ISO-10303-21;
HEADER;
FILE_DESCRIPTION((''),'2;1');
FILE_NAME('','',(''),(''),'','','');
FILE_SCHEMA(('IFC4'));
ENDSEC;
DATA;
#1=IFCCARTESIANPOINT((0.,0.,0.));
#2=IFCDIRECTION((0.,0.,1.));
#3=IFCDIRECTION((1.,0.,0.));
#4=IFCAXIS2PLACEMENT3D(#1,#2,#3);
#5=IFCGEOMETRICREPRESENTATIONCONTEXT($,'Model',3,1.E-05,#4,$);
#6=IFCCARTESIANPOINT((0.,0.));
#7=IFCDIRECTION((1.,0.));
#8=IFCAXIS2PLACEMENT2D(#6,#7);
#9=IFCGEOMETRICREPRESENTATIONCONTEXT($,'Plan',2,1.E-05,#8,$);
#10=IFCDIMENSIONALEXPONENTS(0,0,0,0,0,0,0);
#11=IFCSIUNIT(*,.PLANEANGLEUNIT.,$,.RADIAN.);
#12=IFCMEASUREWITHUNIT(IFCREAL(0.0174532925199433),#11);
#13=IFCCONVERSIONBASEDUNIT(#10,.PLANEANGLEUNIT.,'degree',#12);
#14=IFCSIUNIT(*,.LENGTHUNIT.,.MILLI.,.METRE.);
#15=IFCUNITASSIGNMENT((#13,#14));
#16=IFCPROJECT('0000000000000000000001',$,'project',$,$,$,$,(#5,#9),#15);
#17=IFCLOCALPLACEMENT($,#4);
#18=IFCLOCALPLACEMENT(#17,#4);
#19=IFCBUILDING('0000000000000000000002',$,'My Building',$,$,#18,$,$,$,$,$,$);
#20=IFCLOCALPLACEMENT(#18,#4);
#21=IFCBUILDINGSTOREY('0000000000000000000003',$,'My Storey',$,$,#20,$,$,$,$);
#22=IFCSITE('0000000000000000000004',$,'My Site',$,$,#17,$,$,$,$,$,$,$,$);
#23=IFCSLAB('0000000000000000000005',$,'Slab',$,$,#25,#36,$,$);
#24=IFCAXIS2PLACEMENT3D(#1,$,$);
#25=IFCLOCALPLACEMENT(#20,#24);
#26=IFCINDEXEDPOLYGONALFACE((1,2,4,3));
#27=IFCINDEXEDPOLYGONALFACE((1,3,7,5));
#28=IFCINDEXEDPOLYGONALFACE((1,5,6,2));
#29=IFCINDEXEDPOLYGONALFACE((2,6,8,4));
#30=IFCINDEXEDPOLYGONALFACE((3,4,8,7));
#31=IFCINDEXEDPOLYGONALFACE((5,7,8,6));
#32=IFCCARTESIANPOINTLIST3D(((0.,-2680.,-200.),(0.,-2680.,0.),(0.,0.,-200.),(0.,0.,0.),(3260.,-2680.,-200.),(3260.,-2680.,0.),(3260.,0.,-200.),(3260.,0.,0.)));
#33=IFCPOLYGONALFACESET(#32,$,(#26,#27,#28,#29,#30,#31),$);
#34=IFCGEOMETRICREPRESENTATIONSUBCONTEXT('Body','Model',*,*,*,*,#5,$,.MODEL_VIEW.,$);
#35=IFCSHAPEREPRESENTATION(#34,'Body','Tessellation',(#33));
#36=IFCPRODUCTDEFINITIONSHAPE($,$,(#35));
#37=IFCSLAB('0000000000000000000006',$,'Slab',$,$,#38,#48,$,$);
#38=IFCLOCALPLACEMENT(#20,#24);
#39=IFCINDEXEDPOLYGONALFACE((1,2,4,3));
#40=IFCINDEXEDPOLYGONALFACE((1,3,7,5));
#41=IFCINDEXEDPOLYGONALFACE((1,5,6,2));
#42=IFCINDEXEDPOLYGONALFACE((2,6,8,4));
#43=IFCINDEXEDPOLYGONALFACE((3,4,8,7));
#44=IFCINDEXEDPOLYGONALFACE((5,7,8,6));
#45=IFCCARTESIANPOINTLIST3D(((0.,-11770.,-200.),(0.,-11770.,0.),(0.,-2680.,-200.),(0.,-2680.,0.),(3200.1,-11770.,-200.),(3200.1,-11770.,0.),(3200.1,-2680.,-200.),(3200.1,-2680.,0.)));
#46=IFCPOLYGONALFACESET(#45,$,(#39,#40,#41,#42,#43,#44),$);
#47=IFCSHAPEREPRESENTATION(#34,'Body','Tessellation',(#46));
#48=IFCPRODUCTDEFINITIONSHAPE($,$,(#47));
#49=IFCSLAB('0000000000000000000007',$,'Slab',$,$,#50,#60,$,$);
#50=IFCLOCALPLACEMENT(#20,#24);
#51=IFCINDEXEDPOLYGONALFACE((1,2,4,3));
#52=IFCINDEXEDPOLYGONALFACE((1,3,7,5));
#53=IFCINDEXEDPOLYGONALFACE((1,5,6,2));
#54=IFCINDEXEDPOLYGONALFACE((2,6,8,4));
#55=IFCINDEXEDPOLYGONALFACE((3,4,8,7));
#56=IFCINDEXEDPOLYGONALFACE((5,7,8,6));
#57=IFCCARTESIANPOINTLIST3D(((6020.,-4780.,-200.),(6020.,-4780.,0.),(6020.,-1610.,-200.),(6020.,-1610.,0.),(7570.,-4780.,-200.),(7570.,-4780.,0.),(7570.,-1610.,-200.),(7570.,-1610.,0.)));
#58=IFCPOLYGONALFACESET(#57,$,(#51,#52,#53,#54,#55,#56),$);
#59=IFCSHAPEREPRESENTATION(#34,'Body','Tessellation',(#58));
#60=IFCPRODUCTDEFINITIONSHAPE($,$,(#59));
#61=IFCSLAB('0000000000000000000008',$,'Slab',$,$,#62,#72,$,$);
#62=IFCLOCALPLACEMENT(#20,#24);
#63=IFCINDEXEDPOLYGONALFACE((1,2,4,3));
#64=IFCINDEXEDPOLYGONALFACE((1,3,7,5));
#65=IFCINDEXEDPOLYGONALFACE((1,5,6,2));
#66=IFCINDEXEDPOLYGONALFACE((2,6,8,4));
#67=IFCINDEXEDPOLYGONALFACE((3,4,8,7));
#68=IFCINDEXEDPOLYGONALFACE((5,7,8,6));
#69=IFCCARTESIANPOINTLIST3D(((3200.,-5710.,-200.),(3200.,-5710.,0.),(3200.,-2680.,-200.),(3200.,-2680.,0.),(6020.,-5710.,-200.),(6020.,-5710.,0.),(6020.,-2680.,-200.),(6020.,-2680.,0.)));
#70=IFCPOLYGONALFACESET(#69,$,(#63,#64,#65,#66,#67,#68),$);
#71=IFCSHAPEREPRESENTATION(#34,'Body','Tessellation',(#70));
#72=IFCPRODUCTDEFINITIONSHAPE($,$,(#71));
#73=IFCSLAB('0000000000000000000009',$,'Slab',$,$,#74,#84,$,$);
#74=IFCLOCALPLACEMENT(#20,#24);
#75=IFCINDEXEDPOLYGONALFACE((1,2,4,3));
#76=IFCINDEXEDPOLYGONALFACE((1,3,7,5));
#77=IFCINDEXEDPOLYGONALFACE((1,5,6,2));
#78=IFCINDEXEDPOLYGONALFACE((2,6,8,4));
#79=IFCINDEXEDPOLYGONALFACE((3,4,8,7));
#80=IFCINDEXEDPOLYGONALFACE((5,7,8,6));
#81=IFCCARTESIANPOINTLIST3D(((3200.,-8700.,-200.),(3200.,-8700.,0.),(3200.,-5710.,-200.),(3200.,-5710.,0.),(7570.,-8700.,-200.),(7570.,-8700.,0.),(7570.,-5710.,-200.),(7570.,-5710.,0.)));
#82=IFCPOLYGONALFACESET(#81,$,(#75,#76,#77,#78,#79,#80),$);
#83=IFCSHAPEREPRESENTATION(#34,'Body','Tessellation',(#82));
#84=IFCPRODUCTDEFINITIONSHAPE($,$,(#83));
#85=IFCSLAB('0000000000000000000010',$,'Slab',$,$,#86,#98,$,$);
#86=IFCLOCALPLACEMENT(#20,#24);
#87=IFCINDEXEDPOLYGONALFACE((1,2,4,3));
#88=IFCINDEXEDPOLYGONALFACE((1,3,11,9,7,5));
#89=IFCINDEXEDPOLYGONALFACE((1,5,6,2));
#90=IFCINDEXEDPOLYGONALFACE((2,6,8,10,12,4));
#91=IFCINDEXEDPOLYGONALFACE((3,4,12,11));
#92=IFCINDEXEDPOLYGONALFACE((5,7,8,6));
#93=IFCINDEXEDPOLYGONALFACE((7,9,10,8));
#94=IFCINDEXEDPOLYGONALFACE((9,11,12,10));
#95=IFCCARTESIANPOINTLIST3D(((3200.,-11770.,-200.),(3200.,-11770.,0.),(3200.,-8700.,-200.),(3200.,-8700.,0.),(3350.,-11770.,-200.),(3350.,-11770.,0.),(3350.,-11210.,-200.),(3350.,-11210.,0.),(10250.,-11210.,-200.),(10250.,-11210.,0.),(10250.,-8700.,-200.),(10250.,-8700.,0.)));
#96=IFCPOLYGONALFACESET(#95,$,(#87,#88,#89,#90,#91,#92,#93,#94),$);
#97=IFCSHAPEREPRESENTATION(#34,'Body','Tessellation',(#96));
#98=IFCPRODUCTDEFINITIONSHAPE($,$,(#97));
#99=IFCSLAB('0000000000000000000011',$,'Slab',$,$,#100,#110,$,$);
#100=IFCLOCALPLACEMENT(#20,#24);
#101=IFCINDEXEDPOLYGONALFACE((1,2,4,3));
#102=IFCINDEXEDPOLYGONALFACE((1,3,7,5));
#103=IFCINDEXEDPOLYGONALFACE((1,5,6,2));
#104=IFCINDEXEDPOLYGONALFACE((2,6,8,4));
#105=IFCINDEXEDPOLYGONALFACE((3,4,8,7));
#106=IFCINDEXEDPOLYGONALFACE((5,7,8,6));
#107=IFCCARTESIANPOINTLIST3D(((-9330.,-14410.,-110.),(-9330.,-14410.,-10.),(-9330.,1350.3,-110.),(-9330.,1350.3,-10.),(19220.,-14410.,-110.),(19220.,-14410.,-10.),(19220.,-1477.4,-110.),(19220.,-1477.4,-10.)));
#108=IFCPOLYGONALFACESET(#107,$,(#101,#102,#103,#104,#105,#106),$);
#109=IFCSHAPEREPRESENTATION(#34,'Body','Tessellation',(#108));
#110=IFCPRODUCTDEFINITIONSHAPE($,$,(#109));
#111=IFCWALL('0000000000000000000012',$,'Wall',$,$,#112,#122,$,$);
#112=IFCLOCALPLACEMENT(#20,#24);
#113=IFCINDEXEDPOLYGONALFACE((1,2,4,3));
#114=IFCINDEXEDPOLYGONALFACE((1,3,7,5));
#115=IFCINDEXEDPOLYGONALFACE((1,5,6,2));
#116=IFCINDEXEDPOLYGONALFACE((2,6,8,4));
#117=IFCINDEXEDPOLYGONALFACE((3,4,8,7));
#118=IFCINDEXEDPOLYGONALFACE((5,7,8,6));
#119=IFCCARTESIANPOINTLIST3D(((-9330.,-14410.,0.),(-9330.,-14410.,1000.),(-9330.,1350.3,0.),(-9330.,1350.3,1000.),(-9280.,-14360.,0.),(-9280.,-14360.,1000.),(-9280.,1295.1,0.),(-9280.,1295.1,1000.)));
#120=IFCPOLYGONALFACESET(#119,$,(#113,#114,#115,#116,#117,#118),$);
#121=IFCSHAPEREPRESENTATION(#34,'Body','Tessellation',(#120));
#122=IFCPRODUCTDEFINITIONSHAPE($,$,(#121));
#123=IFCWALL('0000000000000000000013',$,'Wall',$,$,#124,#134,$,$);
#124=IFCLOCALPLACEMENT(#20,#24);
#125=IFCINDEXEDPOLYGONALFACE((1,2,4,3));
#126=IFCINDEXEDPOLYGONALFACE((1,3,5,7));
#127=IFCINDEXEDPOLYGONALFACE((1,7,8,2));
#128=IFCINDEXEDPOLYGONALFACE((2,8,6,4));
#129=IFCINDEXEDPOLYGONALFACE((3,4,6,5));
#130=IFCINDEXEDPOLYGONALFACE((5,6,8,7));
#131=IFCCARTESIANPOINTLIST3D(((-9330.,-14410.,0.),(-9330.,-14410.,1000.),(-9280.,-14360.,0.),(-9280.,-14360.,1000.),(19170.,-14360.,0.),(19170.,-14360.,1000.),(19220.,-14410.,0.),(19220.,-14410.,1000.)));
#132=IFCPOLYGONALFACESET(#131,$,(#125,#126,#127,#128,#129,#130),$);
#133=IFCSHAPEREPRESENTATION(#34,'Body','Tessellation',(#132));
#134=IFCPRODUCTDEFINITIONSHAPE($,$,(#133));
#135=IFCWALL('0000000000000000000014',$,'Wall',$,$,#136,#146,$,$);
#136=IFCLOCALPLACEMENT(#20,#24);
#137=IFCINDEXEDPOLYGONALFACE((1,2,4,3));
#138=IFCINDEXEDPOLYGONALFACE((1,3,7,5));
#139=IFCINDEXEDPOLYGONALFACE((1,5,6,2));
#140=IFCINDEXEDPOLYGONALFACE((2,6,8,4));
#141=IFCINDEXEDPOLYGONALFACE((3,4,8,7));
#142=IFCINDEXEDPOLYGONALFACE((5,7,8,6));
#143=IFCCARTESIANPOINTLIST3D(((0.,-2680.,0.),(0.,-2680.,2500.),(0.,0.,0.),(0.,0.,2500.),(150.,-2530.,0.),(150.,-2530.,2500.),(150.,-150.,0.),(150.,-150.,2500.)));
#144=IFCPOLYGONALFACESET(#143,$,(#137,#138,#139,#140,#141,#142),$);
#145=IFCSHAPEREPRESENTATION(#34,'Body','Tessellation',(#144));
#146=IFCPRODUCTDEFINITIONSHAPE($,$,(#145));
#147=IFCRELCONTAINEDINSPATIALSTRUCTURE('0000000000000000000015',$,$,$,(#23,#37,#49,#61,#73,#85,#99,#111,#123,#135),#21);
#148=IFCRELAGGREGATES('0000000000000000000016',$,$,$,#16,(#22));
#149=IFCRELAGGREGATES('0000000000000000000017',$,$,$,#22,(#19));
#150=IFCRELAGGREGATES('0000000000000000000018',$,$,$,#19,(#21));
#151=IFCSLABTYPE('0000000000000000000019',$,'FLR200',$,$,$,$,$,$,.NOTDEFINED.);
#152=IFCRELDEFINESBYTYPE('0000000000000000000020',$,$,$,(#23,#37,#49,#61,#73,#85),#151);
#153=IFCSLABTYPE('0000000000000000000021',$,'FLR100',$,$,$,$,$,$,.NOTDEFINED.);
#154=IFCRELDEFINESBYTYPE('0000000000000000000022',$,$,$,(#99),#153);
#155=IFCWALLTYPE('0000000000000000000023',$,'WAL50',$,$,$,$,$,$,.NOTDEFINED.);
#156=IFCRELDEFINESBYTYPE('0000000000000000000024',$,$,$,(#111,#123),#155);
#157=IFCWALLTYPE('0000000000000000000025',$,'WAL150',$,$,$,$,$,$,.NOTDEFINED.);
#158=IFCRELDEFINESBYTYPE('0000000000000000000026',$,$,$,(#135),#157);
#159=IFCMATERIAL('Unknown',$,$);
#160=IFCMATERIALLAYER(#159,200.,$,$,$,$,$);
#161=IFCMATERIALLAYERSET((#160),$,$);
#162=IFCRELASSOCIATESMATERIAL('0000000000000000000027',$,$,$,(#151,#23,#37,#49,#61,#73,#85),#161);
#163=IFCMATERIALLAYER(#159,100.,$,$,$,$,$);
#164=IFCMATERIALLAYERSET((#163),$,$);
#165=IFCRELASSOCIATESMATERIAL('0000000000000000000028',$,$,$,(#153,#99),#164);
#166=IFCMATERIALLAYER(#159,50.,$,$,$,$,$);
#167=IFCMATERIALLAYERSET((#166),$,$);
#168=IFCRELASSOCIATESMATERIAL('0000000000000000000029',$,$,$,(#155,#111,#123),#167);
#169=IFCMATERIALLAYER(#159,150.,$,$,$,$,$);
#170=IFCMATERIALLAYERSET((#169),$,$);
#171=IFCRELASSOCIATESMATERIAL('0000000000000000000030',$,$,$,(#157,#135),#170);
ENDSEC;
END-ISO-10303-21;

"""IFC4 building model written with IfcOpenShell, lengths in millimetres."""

from ifc_helpers import new_model, entity, si_unit, converted_unit, frame, origin_with_axes, origin_2d_with_axis, place, context, subcontext, project, spatial, line, indexed_curve, outline, extrude, material, layer, layer_set, layer_usage, type_object, element, save


model = new_model("IFC4")

# Units and contexts
model_context = context("Model", 3, precision=1e-05, world=origin_with_axes())
plan_context = context("Plan", 2, precision=1e-05, world=origin_2d_with_axis())
body_context_1 = subcontext(model_context, "Body", "Model", "MODEL_VIEW")
ifc_project = project(units=[converted_unit("PLANEANGLEUNIT", "degree", entity("IfcReal", 0.0174532925199433), si_unit("PLANEANGLEUNIT", "RADIAN"), dimensions=[0, 0, 0, 0, 0, 0, 0]), si_unit("LENGTHUNIT", "METRE", prefix="MILLI")], contexts=[model_context, plan_context])

# Site, building, storey
site_placement = place(None, origin_with_axes())
site = spatial("IfcSite", under=ifc_project, at=site_placement, Name="My Site")
building_placement = place(site_placement, origin_with_axes())
building = spatial("IfcBuilding", under=site, at=building_placement, Name="My Building")
storey_placement = place(building_placement, origin_with_axes())
storey = spatial("IfcBuildingStorey", under=building, at=storey_placement, Name="My Storey")

# Slabs
ifc_material = material(Name="Unknown")
ifc_layer_1 = layer(ifc_material, 200.0)
ifc_layer_set_1 = layer_set([ifc_layer_1])
ifc_layer_usage_1 = layer_usage(ifc_layer_set_1, "AXIS3", "POSITIVE", -200.0)
slab_type_1 = type_object("IfcSlabType", Name="FLR200", PredefinedType="NOTDEFINED", material=ifc_layer_set_1)
slab_1_placement = place(storey_placement, origin_with_axes())
element("IfcSlab", 1, at=slab_1_placement, inside=storey, type_object=slab_type_1, material=ifc_layer_usage_1, Name="Slab", context=body_context_1, shape_type="SweptSolid", body=[
    extrude(outline(indexed_curve([(0.0, 0.0), (0.0, -2680.0), (3260.0, -2680.0), (3260.0, 0.0), (0.0, 0.0)])), frame((0.0, 0.0, -200.0), z_axis=(0.0, 0.0, 1.0), x_axis=(1.0, 0.0, 0.0)), (0.0, 0.0, 1.0), 200.0),
])
ifc_layer_usage_2 = layer_usage(ifc_layer_set_1, "AXIS3", "POSITIVE", -200.0)
slab_2_placement = place(storey_placement, frame((0.0, -11770.0, 0.0), z_axis=(0.0, 0.0, 1.0), x_axis=(1.0, 0.0, 0.0)))
element("IfcSlab", 2, at=slab_2_placement, inside=storey, type_object=slab_type_1, material=ifc_layer_usage_2, Name="Slab", context=body_context_1, shape_type="SweptSolid", body=[
    extrude(outline(indexed_curve([(0.0, 0.0), (3200.1, 0.0), (3200.1, 9090.0), (0.0, 9090.0), (0.0, 0.0)])), frame((0.0, 0.0, -200.0), z_axis=(0.0, 0.0, 1.0), x_axis=(1.0, 0.0, 0.0)), (0.0, 0.0, 1.0), 200.0),
])
ifc_layer_usage_3 = layer_usage(ifc_layer_set_1, "AXIS3", "POSITIVE", -200.0)
slab_3_placement = place(storey_placement, frame((6020.0, -1610.0, 0.0), z_axis=(0.0, 0.0, 1.0), x_axis=(1.0, 0.0, 0.0)))
element("IfcSlab", 3, at=slab_3_placement, inside=storey, type_object=slab_type_1, material=ifc_layer_usage_3, Name="Slab", context=body_context_1, shape_type="SweptSolid", body=[
    extrude(outline(indexed_curve([(0.0, 0.0), (1550.0, 0.0), (1550.0, -3170.0), (0.0, -3170.0), (0.0, 0.0)])), frame((0.0, 0.0, -200.0), z_axis=(0.0, 0.0, 1.0), x_axis=(1.0, 0.0, 0.0)), (0.0, 0.0, 1.0), 200.0),
])
ifc_layer_usage_4 = layer_usage(ifc_layer_set_1, "AXIS3", "POSITIVE", -200.0)
slab_4_placement = place(storey_placement, frame((3200.0, -2680.0, 0.0), z_axis=(0.0, 0.0, 1.0), x_axis=(1.0, 0.0, 0.0)))
element("IfcSlab", 4, at=slab_4_placement, inside=storey, type_object=slab_type_1, material=ifc_layer_usage_4, Name="Slab", context=body_context_1, shape_type="SweptSolid", body=[
    extrude(outline(indexed_curve([(0.0, 0.0), (2820.0, 0.0), (2820.0, -3030.0), (0.0, -3030.0), (0.0, 0.0)])), frame((0.0, 0.0, -200.0), z_axis=(0.0, 0.0, 1.0), x_axis=(1.0, 0.0, 0.0)), (0.0, 0.0, 1.0), 200.0),
])
ifc_layer_usage_5 = layer_usage(ifc_layer_set_1, "AXIS3", "POSITIVE", -200.0)
slab_5_placement = place(storey_placement, frame((3200.0, -8700.0, 0.0), z_axis=(0.0, 0.0, 1.0), x_axis=(1.0, 0.0, 0.0)))
element("IfcSlab", 5, at=slab_5_placement, inside=storey, type_object=slab_type_1, material=ifc_layer_usage_5, Name="Slab", context=body_context_1, shape_type="SweptSolid", body=[
    extrude(outline(indexed_curve([(0.0, 0.0), (4370.0, 0.0), (4370.0, 2990.0), (0.0, 2990.0), (0.0, 0.0)])), frame((0.0, 0.0, -200.0), z_axis=(0.0, 0.0, 1.0), x_axis=(1.0, 0.0, 0.0)), (0.0, 0.0, 1.0), 200.0),
])
ifc_layer_usage_6 = layer_usage(ifc_layer_set_1, "AXIS3", "POSITIVE", -200.0)
slab_6_placement = place(storey_placement, frame((3200.0, -8700.0, 0.0), z_axis=(0.0, 0.0, 1.0), x_axis=(1.0, 0.0, 0.0)))
element("IfcSlab", 6, at=slab_6_placement, inside=storey, type_object=slab_type_1, material=ifc_layer_usage_6, Name="Slab", context=body_context_1, shape_type="SweptSolid", body=[
    extrude(outline(indexed_curve([(0.0, 0.0), (0.0, -3070.0), (150.0, -3070.0), (150.0, -2510.0), (7050.0, -2510.0), (7050.0, 0.0), (0.0, 0.0)])), frame((0.0, 0.0, -200.0), z_axis=(0.0, 0.0, 1.0), x_axis=(1.0, 0.0, 0.0)), (0.0, 0.0, 1.0), 200.0),
])
ifc_layer_2 = layer(ifc_material, 100.0)
ifc_layer_set_2 = layer_set([ifc_layer_2])
ifc_layer_usage_7 = layer_usage(ifc_layer_set_2, "AXIS3", "POSITIVE", -100.0)
slab_type_2 = type_object("IfcSlabType", Name="FLR100", PredefinedType="NOTDEFINED", material=ifc_layer_set_2)
slab_7_placement = place(storey_placement, frame((-9330.0, 1350.3, -10.0), z_axis=(0.0, 0.0, 1.0), x_axis=(1.0, 0.0, 0.0)))
element("IfcSlab", 7, at=slab_7_placement, inside=storey, type_object=slab_type_2, material=ifc_layer_usage_7, Name="Slab", context=body_context_1, shape_type="SweptSolid", body=[
    extrude(outline(indexed_curve([(28550.0, -2827.7), (28550.0, -15760.3), (0.0, -15760.3), (0.0, 0.0), (28550.0, -2827.7)])), frame((0.0, 0.0, -100.0), z_axis=(0.0, 0.0, 1.0), x_axis=(1.0, 0.0, 0.0)), (0.0, 0.0, 1.0), 100.0),
])

# Walls
ifc_layer_3 = layer(ifc_material, 50.0)
ifc_layer_set_3 = layer_set([ifc_layer_3])
ifc_layer_usage_8 = layer_usage(ifc_layer_set_3, "AXIS2", "POSITIVE", 0.0)
wall_type_1 = type_object("IfcWallType", Name="WAL50", PredefinedType="NOTDEFINED", material=ifc_layer_set_3)
wall_1_placement = place(storey_placement, frame((-9330.0, 1350.3, 0.0), z_axis=(0.0, 0.0, 1.0), x_axis=(0.0, -1.0, 0.0)))
element("IfcWall", 8, at=wall_1_placement, inside=storey, type_object=wall_type_1, material=ifc_layer_usage_8, Name="Wall", context=body_context_1, shape_type="SweptSolid", body=[
    extrude(outline(indexed_curve([(0.0, 0.0), (55.2, 50.0), (15710.3, 50.0), (15760.3, 0.0)], segments=[line(1, 2, 3, 4, 1)])), origin_with_axes(), (0.0, 0.0, 1.0), 1000.0),
])
ifc_layer_usage_9 = layer_usage(ifc_layer_set_3, "AXIS2", "POSITIVE", 0.0)
wall_2_placement = place(storey_placement, frame((-9330.0, -14410.0, 0.0), z_axis=(0.0, 0.0, 1.0), x_axis=(1.0, 0.0, 0.0)))
element("IfcWall", 9, at=wall_2_placement, inside=storey, type_object=wall_type_1, material=ifc_layer_usage_9, Name="Wall", context=body_context_1, shape_type="SweptSolid", body=[
    extrude(outline(indexed_curve([(0.0, 0.0), (50.0, 50.0), (28500.0, 50.0), (28550.0, 0.0)], segments=[line(1, 2, 3, 4, 1)])), origin_with_axes(), (0.0, 0.0, 1.0), 1000.0),
])
ifc_layer_4 = layer(ifc_material, 150.0)
ifc_layer_set_4 = layer_set([ifc_layer_4])
ifc_layer_usage_10 = layer_usage(ifc_layer_set_4, "AXIS2", "POSITIVE", 0.0)
wall_type_2 = type_object("IfcWallType", Name="WAL150", PredefinedType="NOTDEFINED", material=ifc_layer_set_4)
wall_3_placement = place(storey_placement, frame((0.0, 0.0, 0.0), z_axis=(0.0, 0.0, 1.0), x_axis=(0.0, -1.0, 0.0)))
element("IfcWall", 10, at=wall_3_placement, inside=storey, type_object=wall_type_2, material=ifc_layer_usage_10, Name="Wall", context=body_context_1, shape_type="SweptSolid", body=[
    extrude(outline(indexed_curve([(0.0, 0.0), (150.0, 150.0), (2530.0, 150.0), (2680.0, 0.0)], segments=[line(1, 2, 3, 4, 1)])), origin_with_axes(), (0.0, 0.0, 1.0), 2500.0),
])

save(model, "model.ifc")
